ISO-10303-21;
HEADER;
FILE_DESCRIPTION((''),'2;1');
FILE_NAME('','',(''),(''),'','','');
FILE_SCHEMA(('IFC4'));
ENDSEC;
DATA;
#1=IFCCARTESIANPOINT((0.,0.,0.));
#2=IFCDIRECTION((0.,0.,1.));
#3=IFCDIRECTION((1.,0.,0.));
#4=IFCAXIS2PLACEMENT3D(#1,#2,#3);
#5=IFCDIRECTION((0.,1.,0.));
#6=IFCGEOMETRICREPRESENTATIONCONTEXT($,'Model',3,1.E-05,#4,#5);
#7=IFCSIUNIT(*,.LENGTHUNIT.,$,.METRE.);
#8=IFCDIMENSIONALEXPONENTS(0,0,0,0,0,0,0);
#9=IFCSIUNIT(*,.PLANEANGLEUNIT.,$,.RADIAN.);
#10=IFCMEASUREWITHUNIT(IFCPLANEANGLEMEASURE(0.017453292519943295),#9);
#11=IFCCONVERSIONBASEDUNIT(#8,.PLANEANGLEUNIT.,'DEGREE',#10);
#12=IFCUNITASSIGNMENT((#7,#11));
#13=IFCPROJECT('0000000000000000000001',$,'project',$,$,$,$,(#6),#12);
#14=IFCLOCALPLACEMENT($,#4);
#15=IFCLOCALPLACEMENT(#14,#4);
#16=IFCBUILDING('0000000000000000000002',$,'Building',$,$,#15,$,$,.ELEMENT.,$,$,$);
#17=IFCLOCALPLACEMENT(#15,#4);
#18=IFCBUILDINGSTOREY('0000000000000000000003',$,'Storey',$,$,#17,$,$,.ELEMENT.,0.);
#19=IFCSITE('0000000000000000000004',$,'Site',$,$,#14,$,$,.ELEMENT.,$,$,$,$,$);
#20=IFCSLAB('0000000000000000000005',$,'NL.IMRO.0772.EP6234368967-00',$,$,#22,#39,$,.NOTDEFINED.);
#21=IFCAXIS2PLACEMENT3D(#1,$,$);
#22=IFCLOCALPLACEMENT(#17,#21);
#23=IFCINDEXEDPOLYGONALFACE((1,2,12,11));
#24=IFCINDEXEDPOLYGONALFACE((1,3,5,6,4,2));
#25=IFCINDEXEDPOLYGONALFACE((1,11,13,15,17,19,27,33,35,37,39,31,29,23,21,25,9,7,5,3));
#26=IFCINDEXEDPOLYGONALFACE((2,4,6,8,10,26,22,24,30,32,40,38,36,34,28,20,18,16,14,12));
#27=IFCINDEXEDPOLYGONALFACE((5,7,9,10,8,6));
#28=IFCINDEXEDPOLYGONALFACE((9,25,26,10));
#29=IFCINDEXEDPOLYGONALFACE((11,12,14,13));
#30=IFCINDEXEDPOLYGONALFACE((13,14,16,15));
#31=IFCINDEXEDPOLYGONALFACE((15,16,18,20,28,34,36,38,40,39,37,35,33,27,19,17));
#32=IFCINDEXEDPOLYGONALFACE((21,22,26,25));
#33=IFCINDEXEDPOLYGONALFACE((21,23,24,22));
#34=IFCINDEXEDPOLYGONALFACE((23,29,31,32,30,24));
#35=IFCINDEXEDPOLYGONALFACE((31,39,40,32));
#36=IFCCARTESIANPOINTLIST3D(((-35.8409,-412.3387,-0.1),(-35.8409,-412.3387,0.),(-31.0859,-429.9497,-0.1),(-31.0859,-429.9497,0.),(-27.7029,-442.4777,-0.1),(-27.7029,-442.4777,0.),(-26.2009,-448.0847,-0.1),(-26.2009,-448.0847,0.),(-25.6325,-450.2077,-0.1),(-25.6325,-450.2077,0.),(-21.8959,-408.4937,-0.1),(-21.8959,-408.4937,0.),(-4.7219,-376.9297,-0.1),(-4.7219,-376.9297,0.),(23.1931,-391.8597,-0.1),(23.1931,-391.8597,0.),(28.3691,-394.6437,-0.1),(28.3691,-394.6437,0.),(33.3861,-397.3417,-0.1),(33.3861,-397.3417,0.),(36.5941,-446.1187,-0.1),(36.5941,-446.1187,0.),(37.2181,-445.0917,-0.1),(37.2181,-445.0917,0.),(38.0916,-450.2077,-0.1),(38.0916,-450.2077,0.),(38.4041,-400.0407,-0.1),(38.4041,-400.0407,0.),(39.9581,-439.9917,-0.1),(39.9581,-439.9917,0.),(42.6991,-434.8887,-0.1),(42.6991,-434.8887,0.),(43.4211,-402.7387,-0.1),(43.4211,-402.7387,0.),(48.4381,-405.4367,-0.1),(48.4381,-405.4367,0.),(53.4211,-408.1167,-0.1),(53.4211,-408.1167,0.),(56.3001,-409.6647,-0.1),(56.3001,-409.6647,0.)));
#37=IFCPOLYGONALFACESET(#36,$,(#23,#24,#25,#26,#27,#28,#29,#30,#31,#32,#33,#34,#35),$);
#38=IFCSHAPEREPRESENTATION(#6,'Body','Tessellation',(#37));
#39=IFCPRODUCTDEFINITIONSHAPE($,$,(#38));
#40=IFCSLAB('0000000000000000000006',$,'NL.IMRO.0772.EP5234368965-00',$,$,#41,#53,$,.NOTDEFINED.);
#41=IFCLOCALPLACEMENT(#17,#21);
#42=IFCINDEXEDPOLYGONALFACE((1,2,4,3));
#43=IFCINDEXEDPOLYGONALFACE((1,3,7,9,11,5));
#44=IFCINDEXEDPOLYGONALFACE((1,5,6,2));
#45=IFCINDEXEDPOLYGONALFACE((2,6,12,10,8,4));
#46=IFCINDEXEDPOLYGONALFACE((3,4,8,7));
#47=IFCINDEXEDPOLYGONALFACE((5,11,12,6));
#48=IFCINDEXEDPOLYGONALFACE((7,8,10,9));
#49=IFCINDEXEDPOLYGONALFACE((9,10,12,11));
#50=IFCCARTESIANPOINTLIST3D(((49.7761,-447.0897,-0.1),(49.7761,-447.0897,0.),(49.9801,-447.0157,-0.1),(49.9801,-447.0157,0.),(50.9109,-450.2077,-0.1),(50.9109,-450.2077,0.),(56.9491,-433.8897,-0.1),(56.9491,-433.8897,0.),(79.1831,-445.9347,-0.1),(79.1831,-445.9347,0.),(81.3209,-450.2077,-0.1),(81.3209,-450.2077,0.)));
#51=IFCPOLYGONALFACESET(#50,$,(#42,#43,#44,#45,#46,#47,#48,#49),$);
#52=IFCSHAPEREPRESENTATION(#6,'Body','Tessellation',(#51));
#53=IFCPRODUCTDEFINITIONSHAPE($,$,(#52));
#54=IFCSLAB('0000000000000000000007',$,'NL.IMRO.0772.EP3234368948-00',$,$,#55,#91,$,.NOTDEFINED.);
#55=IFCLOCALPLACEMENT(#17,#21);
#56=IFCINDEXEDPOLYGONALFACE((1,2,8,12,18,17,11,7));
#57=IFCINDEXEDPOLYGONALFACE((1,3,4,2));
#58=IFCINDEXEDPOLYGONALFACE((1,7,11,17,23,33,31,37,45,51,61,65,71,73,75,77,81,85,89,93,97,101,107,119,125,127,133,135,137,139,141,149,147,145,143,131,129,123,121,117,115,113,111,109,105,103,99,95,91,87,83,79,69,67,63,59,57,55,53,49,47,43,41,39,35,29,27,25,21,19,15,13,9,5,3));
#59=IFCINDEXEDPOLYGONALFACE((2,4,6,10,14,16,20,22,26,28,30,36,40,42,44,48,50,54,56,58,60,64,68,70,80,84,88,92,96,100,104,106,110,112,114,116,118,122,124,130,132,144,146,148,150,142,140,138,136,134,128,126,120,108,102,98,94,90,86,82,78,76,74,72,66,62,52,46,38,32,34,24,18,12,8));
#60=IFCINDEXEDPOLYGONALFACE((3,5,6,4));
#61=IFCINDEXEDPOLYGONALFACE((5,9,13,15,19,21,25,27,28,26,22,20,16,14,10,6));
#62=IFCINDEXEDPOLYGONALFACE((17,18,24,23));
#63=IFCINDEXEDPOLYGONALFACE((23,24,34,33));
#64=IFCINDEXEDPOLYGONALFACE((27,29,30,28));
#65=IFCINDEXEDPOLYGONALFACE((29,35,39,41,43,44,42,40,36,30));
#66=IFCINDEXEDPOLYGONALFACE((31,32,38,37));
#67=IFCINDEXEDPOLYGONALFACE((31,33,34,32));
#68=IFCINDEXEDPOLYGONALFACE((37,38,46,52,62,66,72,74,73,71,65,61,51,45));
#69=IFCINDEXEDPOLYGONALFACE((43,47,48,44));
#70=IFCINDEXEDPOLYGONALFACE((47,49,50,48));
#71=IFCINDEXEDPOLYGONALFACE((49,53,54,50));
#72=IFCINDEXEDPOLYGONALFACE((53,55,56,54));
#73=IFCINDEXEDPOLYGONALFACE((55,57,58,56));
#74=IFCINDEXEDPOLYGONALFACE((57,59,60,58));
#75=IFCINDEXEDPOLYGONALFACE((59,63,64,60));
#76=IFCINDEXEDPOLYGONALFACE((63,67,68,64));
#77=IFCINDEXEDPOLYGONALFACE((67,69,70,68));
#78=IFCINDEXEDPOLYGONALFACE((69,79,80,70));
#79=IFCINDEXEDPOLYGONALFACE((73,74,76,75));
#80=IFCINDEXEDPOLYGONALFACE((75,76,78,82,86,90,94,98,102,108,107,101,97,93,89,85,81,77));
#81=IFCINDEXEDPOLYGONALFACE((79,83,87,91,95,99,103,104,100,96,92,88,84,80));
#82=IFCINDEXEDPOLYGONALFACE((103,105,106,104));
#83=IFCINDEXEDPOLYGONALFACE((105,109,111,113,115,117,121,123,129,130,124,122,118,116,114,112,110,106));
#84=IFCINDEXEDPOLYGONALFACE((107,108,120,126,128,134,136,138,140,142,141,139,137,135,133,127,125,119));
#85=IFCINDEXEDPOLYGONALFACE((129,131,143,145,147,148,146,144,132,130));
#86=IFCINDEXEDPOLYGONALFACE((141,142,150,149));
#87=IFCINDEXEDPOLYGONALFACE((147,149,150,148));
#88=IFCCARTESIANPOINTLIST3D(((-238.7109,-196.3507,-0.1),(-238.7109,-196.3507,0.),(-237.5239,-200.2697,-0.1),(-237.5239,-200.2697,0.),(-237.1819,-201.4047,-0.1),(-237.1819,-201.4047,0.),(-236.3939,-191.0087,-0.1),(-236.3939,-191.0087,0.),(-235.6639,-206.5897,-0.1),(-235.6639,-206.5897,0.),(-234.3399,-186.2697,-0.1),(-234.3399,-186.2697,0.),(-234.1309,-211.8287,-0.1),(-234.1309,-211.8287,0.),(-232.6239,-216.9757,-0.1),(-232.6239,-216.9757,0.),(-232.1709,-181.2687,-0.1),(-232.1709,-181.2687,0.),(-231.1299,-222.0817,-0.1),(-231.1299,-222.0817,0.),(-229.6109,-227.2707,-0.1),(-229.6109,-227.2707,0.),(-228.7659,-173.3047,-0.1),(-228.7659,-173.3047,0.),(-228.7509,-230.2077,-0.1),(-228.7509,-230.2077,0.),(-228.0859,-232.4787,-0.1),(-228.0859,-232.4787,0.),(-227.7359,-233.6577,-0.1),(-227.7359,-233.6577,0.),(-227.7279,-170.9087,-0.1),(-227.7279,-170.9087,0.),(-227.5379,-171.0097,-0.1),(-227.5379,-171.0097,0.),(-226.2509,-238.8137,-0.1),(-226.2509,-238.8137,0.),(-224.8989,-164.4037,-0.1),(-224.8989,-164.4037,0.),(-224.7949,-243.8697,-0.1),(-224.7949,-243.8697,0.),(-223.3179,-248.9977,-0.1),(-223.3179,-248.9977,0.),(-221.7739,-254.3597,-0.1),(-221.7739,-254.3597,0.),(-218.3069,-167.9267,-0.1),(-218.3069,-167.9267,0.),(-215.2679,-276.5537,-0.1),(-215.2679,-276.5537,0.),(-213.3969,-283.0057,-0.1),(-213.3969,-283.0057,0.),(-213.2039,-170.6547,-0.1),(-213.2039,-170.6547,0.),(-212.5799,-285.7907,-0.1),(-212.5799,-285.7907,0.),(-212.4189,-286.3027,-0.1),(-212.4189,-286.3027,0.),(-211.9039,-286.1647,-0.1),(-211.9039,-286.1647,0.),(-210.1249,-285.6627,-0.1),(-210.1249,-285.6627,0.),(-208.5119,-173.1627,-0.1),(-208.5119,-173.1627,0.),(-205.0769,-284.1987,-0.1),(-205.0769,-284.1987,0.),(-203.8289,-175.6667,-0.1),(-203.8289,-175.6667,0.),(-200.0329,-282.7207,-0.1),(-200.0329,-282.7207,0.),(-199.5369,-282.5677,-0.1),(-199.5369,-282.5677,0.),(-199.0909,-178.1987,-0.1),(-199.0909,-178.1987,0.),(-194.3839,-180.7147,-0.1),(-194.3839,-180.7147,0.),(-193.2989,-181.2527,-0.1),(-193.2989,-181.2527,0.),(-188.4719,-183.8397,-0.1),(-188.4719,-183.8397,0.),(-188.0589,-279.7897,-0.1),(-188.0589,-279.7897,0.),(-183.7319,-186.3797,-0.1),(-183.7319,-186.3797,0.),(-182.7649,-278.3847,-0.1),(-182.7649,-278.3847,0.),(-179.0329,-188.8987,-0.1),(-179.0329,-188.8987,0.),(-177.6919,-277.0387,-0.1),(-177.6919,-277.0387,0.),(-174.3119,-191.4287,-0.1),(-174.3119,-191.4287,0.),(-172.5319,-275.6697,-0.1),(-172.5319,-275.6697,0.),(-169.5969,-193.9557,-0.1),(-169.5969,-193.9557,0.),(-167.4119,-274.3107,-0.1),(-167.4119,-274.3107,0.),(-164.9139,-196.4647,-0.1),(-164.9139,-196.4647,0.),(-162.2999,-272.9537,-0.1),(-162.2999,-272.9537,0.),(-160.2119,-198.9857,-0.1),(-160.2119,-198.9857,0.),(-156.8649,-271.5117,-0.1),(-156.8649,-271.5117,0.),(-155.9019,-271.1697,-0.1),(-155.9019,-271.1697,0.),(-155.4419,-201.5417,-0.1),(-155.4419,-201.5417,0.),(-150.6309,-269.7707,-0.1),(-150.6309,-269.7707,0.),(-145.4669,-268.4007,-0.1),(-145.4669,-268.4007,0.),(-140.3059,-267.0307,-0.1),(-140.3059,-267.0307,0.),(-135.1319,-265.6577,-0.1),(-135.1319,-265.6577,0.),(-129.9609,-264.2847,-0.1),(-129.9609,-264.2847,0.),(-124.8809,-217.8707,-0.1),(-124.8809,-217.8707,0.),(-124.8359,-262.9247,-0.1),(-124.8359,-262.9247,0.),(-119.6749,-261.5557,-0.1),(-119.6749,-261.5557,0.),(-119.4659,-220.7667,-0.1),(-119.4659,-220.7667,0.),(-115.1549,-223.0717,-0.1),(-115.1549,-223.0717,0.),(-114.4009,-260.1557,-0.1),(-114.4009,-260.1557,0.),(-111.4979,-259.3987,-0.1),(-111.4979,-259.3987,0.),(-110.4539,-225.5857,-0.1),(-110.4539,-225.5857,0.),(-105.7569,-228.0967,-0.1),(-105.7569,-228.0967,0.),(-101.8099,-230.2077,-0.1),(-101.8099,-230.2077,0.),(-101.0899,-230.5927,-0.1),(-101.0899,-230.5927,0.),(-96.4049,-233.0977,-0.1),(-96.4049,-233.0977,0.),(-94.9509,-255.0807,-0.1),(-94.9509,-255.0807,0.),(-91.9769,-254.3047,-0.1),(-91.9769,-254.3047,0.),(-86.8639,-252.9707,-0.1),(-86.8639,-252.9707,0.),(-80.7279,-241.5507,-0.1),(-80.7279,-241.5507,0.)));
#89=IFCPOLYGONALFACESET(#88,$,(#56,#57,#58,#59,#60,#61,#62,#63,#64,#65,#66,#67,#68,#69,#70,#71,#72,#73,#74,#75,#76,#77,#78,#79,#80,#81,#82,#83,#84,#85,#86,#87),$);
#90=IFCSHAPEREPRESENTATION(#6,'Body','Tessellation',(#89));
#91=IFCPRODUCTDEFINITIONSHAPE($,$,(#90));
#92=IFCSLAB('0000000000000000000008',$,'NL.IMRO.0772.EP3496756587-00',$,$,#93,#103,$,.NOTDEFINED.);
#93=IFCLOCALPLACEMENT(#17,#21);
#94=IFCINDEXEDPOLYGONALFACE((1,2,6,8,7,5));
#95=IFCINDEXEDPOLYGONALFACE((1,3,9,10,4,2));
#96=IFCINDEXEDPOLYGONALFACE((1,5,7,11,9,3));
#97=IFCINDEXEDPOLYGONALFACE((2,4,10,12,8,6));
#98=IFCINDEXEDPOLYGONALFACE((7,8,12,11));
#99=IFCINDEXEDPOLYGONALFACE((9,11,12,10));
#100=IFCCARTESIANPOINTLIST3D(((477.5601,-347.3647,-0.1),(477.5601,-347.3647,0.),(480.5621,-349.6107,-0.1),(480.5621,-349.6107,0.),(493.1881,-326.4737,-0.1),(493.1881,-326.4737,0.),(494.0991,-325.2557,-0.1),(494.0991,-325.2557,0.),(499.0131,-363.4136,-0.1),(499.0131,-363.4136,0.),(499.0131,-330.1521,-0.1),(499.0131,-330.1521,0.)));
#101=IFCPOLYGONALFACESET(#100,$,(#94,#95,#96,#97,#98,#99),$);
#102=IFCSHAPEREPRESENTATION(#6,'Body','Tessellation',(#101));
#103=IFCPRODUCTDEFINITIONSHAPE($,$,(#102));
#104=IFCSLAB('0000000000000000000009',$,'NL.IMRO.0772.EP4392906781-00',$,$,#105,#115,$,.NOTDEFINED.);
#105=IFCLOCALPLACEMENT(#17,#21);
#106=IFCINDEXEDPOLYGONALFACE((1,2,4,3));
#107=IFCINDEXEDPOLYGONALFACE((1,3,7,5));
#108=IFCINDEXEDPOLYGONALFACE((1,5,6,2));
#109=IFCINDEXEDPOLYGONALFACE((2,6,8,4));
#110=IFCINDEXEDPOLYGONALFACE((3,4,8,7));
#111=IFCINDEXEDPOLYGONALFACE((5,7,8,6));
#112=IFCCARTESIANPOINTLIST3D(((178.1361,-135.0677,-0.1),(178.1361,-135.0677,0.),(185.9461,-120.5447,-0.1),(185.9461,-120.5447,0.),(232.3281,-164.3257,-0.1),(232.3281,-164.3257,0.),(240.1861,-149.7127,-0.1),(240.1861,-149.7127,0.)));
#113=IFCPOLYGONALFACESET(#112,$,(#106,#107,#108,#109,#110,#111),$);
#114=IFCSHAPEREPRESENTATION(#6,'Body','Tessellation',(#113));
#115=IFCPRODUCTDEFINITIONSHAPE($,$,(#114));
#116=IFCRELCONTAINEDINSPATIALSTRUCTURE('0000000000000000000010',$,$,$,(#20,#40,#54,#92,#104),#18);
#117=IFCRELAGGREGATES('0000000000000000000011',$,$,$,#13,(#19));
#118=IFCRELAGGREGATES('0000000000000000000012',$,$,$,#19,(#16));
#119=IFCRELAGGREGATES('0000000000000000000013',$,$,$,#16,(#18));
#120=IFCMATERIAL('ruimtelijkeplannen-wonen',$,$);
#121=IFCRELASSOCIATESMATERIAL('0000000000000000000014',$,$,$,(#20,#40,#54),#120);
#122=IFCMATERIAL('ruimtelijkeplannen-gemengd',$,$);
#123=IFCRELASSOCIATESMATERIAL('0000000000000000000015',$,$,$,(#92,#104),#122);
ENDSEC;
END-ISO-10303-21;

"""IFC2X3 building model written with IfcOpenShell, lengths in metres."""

from ifc_helpers import new_model, entity, si_unit, converted_unit, direction, frame, origin_with_axes, place, context, project, spatial, polyline, outline, extrude, material, element, save


model = new_model("IFC2X3")

# Units and contexts
model_context = context("Model", 3, precision=1e-05, world=origin_with_axes(), true_north=direction((0.0, 1.0, 0.0)))
ifc_project = project(units=[si_unit("LENGTHUNIT", "METRE"), converted_unit("PLANEANGLEUNIT", "DEGREE", entity("IfcPlaneAngleMeasure", 0.017453292519943295), si_unit("PLANEANGLEUNIT", "RADIAN"), dimensions=[0, 0, 0, 0, 0, 0, 0])], contexts=[model_context])

# Site, building, storey
site_placement = place(None, origin_with_axes())
site = spatial("IfcSite", under=ifc_project, at=site_placement, Name="Site", CompositionType="ELEMENT")
building_placement = place(site_placement, origin_with_axes())
building = spatial("IfcBuilding", under=site, at=building_placement, Name="Building", CompositionType="ELEMENT")
storey_placement = place(building_placement, origin_with_axes())
storey = spatial("IfcBuildingStorey", under=building, at=storey_placement, Name="Storey", CompositionType="ELEMENT", Elevation=0.0)

# Slabs
ifc_material_1 = material(Name="ruimtelijkeplannen-wonen")
slab_1_placement = place(storey_placement, frame((0.0, 0.0, -0.1), z_axis=(0.0, 0.0, 1.0), x_axis=(1.0, 0.0, 0.0)))
element("IfcSlab", 1, at=slab_1_placement, inside=storey, material=ifc_material_1, Name="NL.IMRO.0772.EP6234368967-00", PredefinedType="NOTDEFINED", context=model_context, shape_type="SweptSolid", body=[
    extrude(outline(polyline([(-26.2009, -448.0847), (-27.7029, -442.4777), (-31.0859, -429.9497), (-35.8409, -412.3387), (-21.8959, -408.4937), (-4.7219, -376.9297), (23.1931, -391.8597), (28.3691, -394.6437), (33.3861, -397.3417), (38.4041, -400.0407), (43.4211, -402.7387), (48.4381, -405.4367), (53.4211, -408.1167), (56.3001, -409.6647), (42.6991, -434.8887), (39.9581, -439.9917), (37.2181, -445.0917), (36.5941, -446.1187), (38.0916, -450.2077), (-25.6325, -450.2077), (-26.2009, -448.0847)])), origin_with_axes(), (0.0, 0.0, 1.0), 0.1),
])
slab_2_placement = place(storey_placement, frame((0.0, 0.0, -0.1), z_axis=(0.0, 0.0, 1.0), x_axis=(1.0, 0.0, 0.0)))
element("IfcSlab", 2, at=slab_2_placement, inside=storey, material=ifc_material_1, Name="NL.IMRO.0772.EP5234368965-00", PredefinedType="NOTDEFINED", context=model_context, shape_type="SweptSolid", body=[
    extrude(outline(polyline([(49.7761, -447.0897), (49.9801, -447.0157), (56.9491, -433.8897), (79.1831, -445.9347), (81.3209, -450.2077), (50.9109, -450.2077), (49.7761, -447.0897)])), origin_with_axes(), (0.0, 0.0, 1.0), 0.1),
])
slab_3_placement = place(storey_placement, frame((0.0, 0.0, -0.1), z_axis=(0.0, 0.0, 1.0), x_axis=(1.0, 0.0, 0.0)))
element("IfcSlab", 3, at=slab_3_placement, inside=storey, material=ifc_material_1, Name="NL.IMRO.0772.EP3234368948-00", PredefinedType="NOTDEFINED", context=model_context, shape_type="SweptSolid", body=[
    extrude(outline(polyline([(-177.6919, -277.0387), (-182.7649, -278.3847), (-188.0589, -279.7897), (-199.5369, -282.5677), (-200.0329, -282.7207), (-205.0769, -284.1987), (-210.1249, -285.6627), (-211.9039, -286.1647), (-212.4189, -286.3027), (-212.5799, -285.7907), (-213.3969, -283.0057), (-215.2679, -276.5537), (-221.7739, -254.3597), (-223.3179, -248.9977), (-224.7949, -243.8697), (-226.2509, -238.8137), (-227.7359, -233.6577), (-228.0859, -232.4787), (-228.7509, -230.2077), (-229.6109, -227.2707), (-231.1299, -222.0817), (-232.6239, -216.9757), (-234.1309, -211.8287), (-235.6639, -206.5897), (-237.1819, -201.4047), (-237.5239, -200.2697), (-238.7109, -196.3507), (-236.3939, -191.0087), (-234.3399, -186.2697), (-232.1709, -181.2687), (-228.7659, -173.3047), (-227.5379, -171.0097), (-227.7279, -170.9087), (-224.8989, -164.4037), (-218.3069, -167.9267), (-213.2039, -170.6547), (-208.5119, -173.1627), (-203.8289, -175.6667), (-199.0909, -178.1987), (-194.3839, -180.7147), (-193.2989, -181.2527), (-188.4719, -183.8397), (-183.7319, -186.3797), (-179.0329, -188.8987), (-174.3119, -191.4287), (-169.5969, -193.9557), (-164.9139, -196.4647), (-160.2119, -198.9857), (-155.4419, -201.5417), (-124.8809, -217.8707), (-119.4659, -220.7667), (-115.1549, -223.0717), (-110.4539, -225.5857), (-105.7569, -228.0967), (-101.8099, -230.2077), (-101.0899, -230.5927), (-96.4049, -233.0977), (-80.7279, -241.5507), (-86.8639, -252.9707), (-91.9769, -254.3047), (-94.9509, -255.0807), (-111.4979, -259.3987), (-114.4009, -260.1557), (-119.6749, -261.5557), (-124.8359, -262.9247), (-129.9609, -264.2847), (-135.1319, -265.6577), (-140.3059, -267.0307), (-145.4669, -268.4007), (-150.6309, -269.7707), (-155.9019, -271.1697), (-156.8649, -271.5117), (-162.2999, -272.9537), (-167.4119, -274.3107), (-172.5319, -275.6697), (-177.6919, -277.0387)])), origin_with_axes(), (0.0, 0.0, 1.0), 0.1),
])
ifc_material_2 = material(Name="ruimtelijkeplannen-gemengd")
slab_4_placement = place(storey_placement, frame((0.0, 0.0, -0.1), z_axis=(0.0, 0.0, 1.0), x_axis=(1.0, 0.0, 0.0)))
element("IfcSlab", 4, at=slab_4_placement, inside=storey, material=ifc_material_2, Name="NL.IMRO.0772.EP3496756587-00", PredefinedType="NOTDEFINED", context=model_context, shape_type="SweptSolid", body=[
    extrude(outline(polyline([(480.5621, -349.6107), (477.5601, -347.3647), (493.1881, -326.4737), (494.0991, -325.2557), (499.0131, -330.1521), (499.0131, -363.4136), (480.5621, -349.6107)])), origin_with_axes(), (0.0, 0.0, 1.0), 0.1),
])
slab_5_placement = place(storey_placement, frame((0.0, 0.0, -0.1), z_axis=(0.0, 0.0, 1.0), x_axis=(1.0, 0.0, 0.0)))
element("IfcSlab", 5, at=slab_5_placement, inside=storey, material=ifc_material_2, Name="NL.IMRO.0772.EP4392906781-00", PredefinedType="NOTDEFINED", context=model_context, shape_type="SweptSolid", body=[
    extrude(outline(polyline([(240.1861, -149.7127), (232.3281, -164.3257), (178.1361, -135.0677), (185.9461, -120.5447), (240.1861, -149.7127)])), origin_with_axes(), (0.0, 0.0, 1.0), 0.1),
])

save(model, "model.ifc")
